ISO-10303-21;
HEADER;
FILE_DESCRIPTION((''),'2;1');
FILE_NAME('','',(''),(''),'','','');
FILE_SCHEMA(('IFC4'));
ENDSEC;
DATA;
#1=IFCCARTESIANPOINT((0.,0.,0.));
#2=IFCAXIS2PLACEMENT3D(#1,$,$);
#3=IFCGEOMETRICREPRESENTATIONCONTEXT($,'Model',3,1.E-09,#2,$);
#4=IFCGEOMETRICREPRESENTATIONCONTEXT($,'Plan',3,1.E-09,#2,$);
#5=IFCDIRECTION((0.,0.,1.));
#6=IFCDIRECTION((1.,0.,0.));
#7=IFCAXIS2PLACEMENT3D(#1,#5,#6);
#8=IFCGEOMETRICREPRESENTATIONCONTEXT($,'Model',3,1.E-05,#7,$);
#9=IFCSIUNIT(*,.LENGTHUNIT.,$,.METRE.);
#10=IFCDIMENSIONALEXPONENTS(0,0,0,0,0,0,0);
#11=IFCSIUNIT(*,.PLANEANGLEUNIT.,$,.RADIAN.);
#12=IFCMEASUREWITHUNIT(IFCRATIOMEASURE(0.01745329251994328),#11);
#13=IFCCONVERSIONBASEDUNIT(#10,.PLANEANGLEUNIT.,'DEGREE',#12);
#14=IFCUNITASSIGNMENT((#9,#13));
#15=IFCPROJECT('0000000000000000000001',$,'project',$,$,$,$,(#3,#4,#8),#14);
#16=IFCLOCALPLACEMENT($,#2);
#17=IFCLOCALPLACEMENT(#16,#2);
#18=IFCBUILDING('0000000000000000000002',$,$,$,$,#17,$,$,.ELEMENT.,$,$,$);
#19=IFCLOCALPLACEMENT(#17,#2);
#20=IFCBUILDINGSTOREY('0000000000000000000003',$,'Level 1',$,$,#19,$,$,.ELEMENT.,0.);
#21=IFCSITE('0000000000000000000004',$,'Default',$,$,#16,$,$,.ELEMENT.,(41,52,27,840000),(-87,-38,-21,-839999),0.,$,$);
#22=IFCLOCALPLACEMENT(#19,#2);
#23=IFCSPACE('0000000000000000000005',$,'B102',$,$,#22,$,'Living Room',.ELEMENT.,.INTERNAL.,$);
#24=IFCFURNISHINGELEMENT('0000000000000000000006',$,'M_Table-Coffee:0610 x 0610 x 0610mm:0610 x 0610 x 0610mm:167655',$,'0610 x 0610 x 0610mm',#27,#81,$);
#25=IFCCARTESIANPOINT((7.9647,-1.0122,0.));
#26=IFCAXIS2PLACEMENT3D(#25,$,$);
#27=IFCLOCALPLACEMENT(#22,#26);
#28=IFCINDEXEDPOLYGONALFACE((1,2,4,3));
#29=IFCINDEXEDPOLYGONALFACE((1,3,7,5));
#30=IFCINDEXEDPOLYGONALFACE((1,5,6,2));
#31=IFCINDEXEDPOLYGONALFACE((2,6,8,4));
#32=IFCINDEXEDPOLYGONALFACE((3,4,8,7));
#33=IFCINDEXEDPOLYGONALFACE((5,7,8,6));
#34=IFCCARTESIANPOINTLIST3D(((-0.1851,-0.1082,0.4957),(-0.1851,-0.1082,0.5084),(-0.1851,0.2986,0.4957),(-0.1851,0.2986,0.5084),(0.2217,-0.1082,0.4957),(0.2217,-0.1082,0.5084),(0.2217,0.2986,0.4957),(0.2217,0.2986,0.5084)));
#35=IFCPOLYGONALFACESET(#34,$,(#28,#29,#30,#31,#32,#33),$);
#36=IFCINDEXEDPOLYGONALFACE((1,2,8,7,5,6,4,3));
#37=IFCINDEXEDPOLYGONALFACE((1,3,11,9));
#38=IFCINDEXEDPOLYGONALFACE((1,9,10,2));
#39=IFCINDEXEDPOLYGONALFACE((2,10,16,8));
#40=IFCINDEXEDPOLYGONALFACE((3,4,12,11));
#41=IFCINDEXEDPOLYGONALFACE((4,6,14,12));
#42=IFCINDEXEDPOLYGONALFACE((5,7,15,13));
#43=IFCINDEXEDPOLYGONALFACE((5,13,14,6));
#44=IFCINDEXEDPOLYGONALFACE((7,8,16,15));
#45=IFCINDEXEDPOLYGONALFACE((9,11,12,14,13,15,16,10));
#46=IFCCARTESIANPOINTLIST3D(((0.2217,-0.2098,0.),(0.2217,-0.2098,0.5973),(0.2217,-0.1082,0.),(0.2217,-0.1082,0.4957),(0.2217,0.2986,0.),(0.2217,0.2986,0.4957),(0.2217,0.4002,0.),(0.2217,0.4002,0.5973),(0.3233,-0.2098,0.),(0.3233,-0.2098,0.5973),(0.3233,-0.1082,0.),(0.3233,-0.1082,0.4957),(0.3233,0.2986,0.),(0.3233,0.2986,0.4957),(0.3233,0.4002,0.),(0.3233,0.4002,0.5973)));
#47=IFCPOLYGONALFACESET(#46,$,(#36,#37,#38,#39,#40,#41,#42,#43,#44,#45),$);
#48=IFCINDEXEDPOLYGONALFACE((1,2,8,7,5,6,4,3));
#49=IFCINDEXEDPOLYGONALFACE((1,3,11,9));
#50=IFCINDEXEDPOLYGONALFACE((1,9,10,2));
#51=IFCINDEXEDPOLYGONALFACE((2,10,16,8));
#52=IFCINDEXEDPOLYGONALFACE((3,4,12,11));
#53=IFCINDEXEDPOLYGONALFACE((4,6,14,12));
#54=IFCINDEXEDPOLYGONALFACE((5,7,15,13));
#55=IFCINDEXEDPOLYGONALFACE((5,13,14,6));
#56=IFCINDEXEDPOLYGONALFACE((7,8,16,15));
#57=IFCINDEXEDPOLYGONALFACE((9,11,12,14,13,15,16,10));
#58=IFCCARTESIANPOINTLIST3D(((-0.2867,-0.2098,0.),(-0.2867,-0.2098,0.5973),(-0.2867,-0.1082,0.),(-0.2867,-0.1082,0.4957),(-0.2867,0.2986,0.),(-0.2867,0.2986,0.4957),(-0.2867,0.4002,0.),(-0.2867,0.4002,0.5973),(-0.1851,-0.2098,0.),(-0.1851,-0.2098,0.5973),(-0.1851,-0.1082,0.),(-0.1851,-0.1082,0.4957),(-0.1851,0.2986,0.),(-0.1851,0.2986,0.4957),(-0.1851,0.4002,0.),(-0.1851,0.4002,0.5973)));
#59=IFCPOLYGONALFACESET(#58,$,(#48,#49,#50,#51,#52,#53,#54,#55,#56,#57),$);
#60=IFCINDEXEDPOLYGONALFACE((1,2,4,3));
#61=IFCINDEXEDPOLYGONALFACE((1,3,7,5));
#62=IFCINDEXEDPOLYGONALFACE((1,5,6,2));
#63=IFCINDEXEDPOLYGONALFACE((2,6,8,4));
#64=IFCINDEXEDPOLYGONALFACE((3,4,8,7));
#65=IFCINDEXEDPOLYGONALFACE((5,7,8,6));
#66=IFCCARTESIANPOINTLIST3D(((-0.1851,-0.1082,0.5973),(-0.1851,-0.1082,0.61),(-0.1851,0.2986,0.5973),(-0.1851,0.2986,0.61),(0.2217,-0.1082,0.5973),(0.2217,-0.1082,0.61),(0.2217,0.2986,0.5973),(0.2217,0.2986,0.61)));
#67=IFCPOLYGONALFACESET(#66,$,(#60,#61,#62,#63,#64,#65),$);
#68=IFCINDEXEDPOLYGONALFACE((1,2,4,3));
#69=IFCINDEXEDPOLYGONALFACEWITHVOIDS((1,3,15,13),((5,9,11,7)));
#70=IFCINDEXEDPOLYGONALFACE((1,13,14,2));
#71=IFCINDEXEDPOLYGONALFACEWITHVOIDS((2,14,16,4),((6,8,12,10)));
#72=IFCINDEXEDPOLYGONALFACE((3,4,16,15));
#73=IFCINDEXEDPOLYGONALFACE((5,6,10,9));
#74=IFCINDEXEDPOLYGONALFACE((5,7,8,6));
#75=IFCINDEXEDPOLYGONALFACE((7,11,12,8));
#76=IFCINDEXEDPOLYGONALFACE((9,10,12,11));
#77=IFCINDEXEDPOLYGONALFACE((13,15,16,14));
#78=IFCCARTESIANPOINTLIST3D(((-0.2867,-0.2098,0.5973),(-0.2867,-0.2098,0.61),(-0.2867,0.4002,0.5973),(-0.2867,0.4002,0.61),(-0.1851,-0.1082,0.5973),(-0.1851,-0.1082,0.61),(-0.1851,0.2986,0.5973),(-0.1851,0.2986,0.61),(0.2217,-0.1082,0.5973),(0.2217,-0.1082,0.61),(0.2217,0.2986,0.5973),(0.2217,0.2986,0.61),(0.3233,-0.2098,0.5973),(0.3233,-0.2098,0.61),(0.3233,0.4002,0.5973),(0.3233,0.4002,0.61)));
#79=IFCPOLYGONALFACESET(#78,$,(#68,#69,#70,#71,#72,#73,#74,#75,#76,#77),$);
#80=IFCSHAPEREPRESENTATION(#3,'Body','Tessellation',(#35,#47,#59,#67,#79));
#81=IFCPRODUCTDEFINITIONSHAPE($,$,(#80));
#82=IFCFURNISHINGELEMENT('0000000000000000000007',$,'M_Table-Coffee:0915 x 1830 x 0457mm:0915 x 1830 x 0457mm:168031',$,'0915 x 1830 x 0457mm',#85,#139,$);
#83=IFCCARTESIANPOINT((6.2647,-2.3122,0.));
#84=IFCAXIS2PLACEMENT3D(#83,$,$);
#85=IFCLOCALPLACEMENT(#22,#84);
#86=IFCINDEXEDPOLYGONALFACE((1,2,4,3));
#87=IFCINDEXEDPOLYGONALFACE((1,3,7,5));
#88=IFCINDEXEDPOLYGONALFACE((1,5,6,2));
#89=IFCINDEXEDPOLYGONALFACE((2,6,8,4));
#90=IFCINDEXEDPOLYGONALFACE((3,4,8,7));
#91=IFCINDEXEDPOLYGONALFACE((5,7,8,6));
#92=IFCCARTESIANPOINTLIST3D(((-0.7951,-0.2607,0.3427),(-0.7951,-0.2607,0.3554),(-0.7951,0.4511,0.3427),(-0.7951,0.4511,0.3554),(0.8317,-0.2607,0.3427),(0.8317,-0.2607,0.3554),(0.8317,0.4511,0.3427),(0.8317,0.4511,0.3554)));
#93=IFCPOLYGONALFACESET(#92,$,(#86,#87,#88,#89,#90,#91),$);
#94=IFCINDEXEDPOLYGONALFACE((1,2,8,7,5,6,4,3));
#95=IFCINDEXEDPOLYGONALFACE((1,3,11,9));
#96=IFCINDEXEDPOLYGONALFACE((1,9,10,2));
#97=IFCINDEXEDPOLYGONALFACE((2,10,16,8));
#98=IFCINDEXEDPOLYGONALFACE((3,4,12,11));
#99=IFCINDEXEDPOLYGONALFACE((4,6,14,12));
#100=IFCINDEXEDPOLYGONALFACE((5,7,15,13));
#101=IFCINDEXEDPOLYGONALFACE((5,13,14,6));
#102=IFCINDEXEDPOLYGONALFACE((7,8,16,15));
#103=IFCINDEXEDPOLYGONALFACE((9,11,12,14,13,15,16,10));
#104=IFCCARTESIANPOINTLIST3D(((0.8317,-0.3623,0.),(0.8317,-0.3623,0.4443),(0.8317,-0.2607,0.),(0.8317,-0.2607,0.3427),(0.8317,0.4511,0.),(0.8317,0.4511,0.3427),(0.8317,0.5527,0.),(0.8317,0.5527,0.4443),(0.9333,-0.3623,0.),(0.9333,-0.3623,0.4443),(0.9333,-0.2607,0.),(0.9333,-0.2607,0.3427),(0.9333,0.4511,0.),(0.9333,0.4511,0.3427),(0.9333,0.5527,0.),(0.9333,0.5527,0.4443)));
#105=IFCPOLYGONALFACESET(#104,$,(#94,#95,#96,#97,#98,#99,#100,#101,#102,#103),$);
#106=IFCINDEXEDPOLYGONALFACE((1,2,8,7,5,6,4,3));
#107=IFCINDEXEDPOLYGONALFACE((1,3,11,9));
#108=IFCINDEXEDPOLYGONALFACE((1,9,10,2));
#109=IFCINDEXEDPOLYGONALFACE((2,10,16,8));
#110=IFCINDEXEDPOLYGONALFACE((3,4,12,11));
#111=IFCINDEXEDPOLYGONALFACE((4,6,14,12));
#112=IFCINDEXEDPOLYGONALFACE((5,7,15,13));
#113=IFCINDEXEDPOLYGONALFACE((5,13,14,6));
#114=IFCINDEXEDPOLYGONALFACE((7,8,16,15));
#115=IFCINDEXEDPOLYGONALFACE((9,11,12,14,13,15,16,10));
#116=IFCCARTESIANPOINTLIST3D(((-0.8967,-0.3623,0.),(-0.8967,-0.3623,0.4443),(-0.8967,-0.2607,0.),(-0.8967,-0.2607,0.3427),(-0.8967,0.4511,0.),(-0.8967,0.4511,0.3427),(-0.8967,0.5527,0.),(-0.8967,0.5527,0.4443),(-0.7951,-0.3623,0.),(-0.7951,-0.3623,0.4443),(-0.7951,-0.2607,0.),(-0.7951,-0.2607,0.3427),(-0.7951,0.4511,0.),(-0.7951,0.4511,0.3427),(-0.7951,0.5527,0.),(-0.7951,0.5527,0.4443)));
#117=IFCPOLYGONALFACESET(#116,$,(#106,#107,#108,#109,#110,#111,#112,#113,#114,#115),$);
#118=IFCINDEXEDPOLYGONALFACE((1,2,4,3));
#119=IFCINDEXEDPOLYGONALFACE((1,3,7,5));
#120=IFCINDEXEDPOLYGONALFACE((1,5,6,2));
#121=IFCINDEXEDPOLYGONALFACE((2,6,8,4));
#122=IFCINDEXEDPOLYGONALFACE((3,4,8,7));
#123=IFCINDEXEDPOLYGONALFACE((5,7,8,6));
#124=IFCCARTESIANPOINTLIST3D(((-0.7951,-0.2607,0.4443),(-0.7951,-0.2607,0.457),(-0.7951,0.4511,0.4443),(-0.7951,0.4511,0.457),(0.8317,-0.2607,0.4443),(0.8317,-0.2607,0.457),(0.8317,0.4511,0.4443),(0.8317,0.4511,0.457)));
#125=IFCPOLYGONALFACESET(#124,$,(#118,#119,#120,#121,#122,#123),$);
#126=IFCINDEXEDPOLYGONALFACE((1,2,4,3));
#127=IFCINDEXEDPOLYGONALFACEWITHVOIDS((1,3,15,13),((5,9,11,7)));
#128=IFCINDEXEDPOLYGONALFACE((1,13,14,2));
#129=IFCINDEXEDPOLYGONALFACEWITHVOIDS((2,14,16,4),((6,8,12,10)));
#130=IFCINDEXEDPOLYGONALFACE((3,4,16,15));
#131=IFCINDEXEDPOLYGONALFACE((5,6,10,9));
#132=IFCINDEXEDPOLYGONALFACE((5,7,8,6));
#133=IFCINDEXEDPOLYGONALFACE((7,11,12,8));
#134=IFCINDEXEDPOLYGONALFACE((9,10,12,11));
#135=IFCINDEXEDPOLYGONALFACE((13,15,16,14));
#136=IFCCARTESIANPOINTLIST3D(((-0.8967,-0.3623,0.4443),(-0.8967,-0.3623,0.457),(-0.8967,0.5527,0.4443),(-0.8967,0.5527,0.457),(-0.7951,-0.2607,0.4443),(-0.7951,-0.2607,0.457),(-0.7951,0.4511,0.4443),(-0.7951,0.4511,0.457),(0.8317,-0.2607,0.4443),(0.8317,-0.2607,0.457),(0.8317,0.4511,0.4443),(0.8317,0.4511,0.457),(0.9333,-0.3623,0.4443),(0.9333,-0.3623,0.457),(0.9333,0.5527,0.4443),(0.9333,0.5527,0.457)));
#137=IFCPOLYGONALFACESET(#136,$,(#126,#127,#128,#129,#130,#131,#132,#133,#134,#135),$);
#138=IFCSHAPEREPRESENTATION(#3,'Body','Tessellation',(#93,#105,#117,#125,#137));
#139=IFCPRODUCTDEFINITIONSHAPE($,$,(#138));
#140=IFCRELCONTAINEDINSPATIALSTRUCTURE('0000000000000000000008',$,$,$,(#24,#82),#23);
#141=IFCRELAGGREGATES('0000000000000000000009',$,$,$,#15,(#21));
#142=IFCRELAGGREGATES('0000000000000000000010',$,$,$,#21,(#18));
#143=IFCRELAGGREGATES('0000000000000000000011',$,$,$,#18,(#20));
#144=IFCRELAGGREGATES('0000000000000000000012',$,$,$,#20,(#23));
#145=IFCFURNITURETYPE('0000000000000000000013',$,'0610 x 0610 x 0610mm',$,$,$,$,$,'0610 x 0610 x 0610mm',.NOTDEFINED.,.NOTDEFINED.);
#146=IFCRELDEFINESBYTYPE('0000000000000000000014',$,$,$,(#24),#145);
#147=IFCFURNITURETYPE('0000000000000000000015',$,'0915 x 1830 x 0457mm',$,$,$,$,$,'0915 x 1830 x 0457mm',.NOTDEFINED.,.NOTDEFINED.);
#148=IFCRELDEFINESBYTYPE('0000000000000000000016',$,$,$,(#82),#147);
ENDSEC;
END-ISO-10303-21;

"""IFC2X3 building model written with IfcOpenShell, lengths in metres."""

from ifc_helpers import new_model, entity, si_unit, converted_unit, frame, origin, origin_with_axes, origin_2d_with_axis, place, context, project, spatial, polyline, rectangle, outline, extrude, source, transform, mapped, type_object, type_shapes, element, save


model = new_model("IFC2X3")

# Units and contexts
model_context_1 = context("Model", 3, precision=1e-09, world=origin())
plan_context = context("Plan", 3, precision=1e-09, world=origin())
model_context_2 = context("Model", 3, precision=1e-05, world=origin_with_axes())
ifc_project = project(units=[si_unit("LENGTHUNIT", "METRE"), converted_unit("PLANEANGLEUNIT", "DEGREE", entity("IfcRatioMeasure", 0.01745329251994328), si_unit("PLANEANGLEUNIT", "RADIAN"), dimensions=[0, 0, 0, 0, 0, 0, 0])], contexts=[model_context_1, plan_context, model_context_2])

# Site, building, storey
site_placement = place(None, origin())
site = spatial("IfcSite", under=ifc_project, at=site_placement, Name="Default", CompositionType="ELEMENT", RefLatitude=(41, 52, 27, 840000), RefLongitude=(-87, -38, -21, -839999), RefElevation=0.0)
building_placement = place(site_placement, origin())
building = spatial("IfcBuilding", under=site, at=building_placement, CompositionType="ELEMENT")
storey_placement = place(building_placement, origin())
storey = spatial("IfcBuildingStorey", under=building, at=storey_placement, Name="Level 1", CompositionType="ELEMENT", Elevation=0.0)

# Shared definitions
space_placement = place(storey_placement, origin())
space = spatial("IfcSpace", under=storey, at=space_placement, Name="B102", LongName="Living Room", CompositionType="ELEMENT", InteriorOrExteriorSpace="INTERNAL")

# Furnishing elements
furniture_type_1 = type_object("IfcFurnitureType", Name="0610 x 0610 x 0610mm", ElementType="0610 x 0610 x 0610mm", AssemblyPlace="NOTDEFINED")
shared_shape_1 = source(origin(), model_context_1, "Body", "SweptSolid", [
    extrude(rectangle(XDim=0.4068, YDim=0.4068, at=origin_2d_with_axis()), frame((0.0183, 0.0952, 0.4957), z_axis=(0.0, 0.0, 1.0), x_axis=(-1.0, 0.0, 0.0)), (0.0, 0.0, 1.0), 0.0127),
    extrude(outline(polyline([(-0.2732, -0.305), (0.324, -0.305), (0.324, 0.305), (-0.2732, 0.305), (-0.2732, 0.2034), (0.2225, 0.2034), (0.2225, -0.2034), (-0.2732, -0.2034), (-0.2732, -0.305)])), frame((0.2217, 0.0952, 0.2732), z_axis=(1.0, 0.0, 0.0), x_axis=(0.0, 0.0, 1.0)), (0.0, 0.0, 1.0), 0.1016),
    extrude(outline(polyline([(-0.305, -0.3241), (0.305, -0.3241), (0.305, 0.2733), (0.2034, 0.2733), (0.2034, -0.2224), (-0.2034, -0.2224), (-0.2034, 0.2733), (-0.305, 0.2733), (-0.305, -0.3241)])), frame((-0.2867, 0.0952, 0.2733), z_axis=(1.0, 0.0, 0.0), x_axis=(0.0, -1.0, 0.0)), (0.0, 0.0, 1.0), 0.1016),
    extrude(rectangle(XDim=0.4068, YDim=0.4068, at=origin_2d_with_axis()), frame((0.0183, 0.0952, 0.5973), z_axis=(0.0, 0.0, 1.0), x_axis=(-1.0, 0.0, 0.0)), (0.0, 0.0, 1.0), 0.0127),
    extrude(outline(polyline([(-0.305, -0.305), (0.305, -0.305), (0.305, 0.305), (-0.305, 0.305), (-0.305, -0.305)]), holes=[polyline([(-0.2034, -0.2034), (-0.2034, 0.2034), (0.2034, 0.2034), (0.2034, -0.2034), (-0.2034, -0.2034)])]), frame((0.0183, 0.0952, 0.5973), z_axis=(0.0, 0.0, 1.0), x_axis=(-1.0, 0.0, 0.0)), (0.0, 0.0, 1.0), 0.0127),
])
type_shapes(furniture_type_1, [shared_shape_1])
furnishing_1_placement = place(space_placement, frame((7.9647, -1.0122, 0.0)))
element("IfcFurnishingElement", 1, at=furnishing_1_placement, inside=space, type_object=furniture_type_1, Name="M_Table-Coffee:0610 x 0610 x 0610mm:0610 x 0610 x 0610mm:167655", ObjectType="0610 x 0610 x 0610mm", context=model_context_1, shape_type="MappedRepresentation", body=[
    mapped(shared_shape_1, transform((0.0, 0.0, 0.0), scale=1.0)),
])
furniture_type_2 = type_object("IfcFurnitureType", Name="0915 x 1830 x 0457mm", ElementType="0915 x 1830 x 0457mm", AssemblyPlace="NOTDEFINED")
shared_shape_2 = source(origin(), model_context_1, "Body", "SweptSolid", [
    extrude(rectangle(XDim=1.6268, YDim=0.7118, at=origin_2d_with_axis()), frame((0.0183, 0.0952, 0.3427), z_axis=(0.0, 0.0, 1.0), x_axis=(-1.0, 0.0, 0.0)), (0.0, 0.0, 1.0), 0.0127),
    extrude(outline(polyline([(-0.1967, -0.4575), (0.2475, -0.4575), (0.2475, 0.4575), (-0.1967, 0.4575), (-0.1967, 0.3559), (0.146, 0.3559), (0.146, -0.3559), (-0.1967, -0.3559), (-0.1967, -0.4575)])), frame((0.8317, 0.0952, 0.1967), z_axis=(1.0, 0.0, 0.0), x_axis=(0.0, 0.0, 1.0)), (0.0, 0.0, 1.0), 0.1016),
    extrude(outline(polyline([(-0.4575, -0.2476), (0.4575, -0.2476), (0.4575, 0.1968), (0.3559, 0.1968), (0.3559, -0.1459), (-0.3559, -0.1459), (-0.3559, 0.1968), (-0.4575, 0.1968), (-0.4575, -0.2476)])), frame((-0.8967, 0.0952, 0.1968), z_axis=(1.0, 0.0, 0.0), x_axis=(0.0, -1.0, 0.0)), (0.0, 0.0, 1.0), 0.1016),
    extrude(rectangle(XDim=1.6268, YDim=0.7118, at=origin_2d_with_axis()), frame((0.0183, 0.0952, 0.4443), z_axis=(0.0, 0.0, 1.0), x_axis=(-1.0, 0.0, 0.0)), (0.0, 0.0, 1.0), 0.0127),
    extrude(outline(polyline([(-0.915, -0.4575), (0.915, -0.4575), (0.915, 0.4575), (-0.915, 0.4575), (-0.915, -0.4575)]), holes=[polyline([(-0.8134, -0.3559), (-0.8134, 0.3559), (0.8134, 0.3559), (0.8134, -0.3559), (-0.8134, -0.3559)])]), frame((0.0183, 0.0952, 0.4443), z_axis=(0.0, 0.0, 1.0), x_axis=(-1.0, 0.0, 0.0)), (0.0, 0.0, 1.0), 0.0127),
])
type_shapes(furniture_type_2, [shared_shape_2])
furnishing_2_placement = place(space_placement, frame((6.2647, -2.3122, 0.0)))
element("IfcFurnishingElement", 2, at=furnishing_2_placement, inside=space, type_object=furniture_type_2, Name="M_Table-Coffee:0915 x 1830 x 0457mm:0915 x 1830 x 0457mm:168031", ObjectType="0915 x 1830 x 0457mm", context=model_context_1, shape_type="MappedRepresentation", body=[
    mapped(shared_shape_2, transform((0.0, 0.0, 0.0), scale=1.0)),
])

save(model, "model.ifc")
